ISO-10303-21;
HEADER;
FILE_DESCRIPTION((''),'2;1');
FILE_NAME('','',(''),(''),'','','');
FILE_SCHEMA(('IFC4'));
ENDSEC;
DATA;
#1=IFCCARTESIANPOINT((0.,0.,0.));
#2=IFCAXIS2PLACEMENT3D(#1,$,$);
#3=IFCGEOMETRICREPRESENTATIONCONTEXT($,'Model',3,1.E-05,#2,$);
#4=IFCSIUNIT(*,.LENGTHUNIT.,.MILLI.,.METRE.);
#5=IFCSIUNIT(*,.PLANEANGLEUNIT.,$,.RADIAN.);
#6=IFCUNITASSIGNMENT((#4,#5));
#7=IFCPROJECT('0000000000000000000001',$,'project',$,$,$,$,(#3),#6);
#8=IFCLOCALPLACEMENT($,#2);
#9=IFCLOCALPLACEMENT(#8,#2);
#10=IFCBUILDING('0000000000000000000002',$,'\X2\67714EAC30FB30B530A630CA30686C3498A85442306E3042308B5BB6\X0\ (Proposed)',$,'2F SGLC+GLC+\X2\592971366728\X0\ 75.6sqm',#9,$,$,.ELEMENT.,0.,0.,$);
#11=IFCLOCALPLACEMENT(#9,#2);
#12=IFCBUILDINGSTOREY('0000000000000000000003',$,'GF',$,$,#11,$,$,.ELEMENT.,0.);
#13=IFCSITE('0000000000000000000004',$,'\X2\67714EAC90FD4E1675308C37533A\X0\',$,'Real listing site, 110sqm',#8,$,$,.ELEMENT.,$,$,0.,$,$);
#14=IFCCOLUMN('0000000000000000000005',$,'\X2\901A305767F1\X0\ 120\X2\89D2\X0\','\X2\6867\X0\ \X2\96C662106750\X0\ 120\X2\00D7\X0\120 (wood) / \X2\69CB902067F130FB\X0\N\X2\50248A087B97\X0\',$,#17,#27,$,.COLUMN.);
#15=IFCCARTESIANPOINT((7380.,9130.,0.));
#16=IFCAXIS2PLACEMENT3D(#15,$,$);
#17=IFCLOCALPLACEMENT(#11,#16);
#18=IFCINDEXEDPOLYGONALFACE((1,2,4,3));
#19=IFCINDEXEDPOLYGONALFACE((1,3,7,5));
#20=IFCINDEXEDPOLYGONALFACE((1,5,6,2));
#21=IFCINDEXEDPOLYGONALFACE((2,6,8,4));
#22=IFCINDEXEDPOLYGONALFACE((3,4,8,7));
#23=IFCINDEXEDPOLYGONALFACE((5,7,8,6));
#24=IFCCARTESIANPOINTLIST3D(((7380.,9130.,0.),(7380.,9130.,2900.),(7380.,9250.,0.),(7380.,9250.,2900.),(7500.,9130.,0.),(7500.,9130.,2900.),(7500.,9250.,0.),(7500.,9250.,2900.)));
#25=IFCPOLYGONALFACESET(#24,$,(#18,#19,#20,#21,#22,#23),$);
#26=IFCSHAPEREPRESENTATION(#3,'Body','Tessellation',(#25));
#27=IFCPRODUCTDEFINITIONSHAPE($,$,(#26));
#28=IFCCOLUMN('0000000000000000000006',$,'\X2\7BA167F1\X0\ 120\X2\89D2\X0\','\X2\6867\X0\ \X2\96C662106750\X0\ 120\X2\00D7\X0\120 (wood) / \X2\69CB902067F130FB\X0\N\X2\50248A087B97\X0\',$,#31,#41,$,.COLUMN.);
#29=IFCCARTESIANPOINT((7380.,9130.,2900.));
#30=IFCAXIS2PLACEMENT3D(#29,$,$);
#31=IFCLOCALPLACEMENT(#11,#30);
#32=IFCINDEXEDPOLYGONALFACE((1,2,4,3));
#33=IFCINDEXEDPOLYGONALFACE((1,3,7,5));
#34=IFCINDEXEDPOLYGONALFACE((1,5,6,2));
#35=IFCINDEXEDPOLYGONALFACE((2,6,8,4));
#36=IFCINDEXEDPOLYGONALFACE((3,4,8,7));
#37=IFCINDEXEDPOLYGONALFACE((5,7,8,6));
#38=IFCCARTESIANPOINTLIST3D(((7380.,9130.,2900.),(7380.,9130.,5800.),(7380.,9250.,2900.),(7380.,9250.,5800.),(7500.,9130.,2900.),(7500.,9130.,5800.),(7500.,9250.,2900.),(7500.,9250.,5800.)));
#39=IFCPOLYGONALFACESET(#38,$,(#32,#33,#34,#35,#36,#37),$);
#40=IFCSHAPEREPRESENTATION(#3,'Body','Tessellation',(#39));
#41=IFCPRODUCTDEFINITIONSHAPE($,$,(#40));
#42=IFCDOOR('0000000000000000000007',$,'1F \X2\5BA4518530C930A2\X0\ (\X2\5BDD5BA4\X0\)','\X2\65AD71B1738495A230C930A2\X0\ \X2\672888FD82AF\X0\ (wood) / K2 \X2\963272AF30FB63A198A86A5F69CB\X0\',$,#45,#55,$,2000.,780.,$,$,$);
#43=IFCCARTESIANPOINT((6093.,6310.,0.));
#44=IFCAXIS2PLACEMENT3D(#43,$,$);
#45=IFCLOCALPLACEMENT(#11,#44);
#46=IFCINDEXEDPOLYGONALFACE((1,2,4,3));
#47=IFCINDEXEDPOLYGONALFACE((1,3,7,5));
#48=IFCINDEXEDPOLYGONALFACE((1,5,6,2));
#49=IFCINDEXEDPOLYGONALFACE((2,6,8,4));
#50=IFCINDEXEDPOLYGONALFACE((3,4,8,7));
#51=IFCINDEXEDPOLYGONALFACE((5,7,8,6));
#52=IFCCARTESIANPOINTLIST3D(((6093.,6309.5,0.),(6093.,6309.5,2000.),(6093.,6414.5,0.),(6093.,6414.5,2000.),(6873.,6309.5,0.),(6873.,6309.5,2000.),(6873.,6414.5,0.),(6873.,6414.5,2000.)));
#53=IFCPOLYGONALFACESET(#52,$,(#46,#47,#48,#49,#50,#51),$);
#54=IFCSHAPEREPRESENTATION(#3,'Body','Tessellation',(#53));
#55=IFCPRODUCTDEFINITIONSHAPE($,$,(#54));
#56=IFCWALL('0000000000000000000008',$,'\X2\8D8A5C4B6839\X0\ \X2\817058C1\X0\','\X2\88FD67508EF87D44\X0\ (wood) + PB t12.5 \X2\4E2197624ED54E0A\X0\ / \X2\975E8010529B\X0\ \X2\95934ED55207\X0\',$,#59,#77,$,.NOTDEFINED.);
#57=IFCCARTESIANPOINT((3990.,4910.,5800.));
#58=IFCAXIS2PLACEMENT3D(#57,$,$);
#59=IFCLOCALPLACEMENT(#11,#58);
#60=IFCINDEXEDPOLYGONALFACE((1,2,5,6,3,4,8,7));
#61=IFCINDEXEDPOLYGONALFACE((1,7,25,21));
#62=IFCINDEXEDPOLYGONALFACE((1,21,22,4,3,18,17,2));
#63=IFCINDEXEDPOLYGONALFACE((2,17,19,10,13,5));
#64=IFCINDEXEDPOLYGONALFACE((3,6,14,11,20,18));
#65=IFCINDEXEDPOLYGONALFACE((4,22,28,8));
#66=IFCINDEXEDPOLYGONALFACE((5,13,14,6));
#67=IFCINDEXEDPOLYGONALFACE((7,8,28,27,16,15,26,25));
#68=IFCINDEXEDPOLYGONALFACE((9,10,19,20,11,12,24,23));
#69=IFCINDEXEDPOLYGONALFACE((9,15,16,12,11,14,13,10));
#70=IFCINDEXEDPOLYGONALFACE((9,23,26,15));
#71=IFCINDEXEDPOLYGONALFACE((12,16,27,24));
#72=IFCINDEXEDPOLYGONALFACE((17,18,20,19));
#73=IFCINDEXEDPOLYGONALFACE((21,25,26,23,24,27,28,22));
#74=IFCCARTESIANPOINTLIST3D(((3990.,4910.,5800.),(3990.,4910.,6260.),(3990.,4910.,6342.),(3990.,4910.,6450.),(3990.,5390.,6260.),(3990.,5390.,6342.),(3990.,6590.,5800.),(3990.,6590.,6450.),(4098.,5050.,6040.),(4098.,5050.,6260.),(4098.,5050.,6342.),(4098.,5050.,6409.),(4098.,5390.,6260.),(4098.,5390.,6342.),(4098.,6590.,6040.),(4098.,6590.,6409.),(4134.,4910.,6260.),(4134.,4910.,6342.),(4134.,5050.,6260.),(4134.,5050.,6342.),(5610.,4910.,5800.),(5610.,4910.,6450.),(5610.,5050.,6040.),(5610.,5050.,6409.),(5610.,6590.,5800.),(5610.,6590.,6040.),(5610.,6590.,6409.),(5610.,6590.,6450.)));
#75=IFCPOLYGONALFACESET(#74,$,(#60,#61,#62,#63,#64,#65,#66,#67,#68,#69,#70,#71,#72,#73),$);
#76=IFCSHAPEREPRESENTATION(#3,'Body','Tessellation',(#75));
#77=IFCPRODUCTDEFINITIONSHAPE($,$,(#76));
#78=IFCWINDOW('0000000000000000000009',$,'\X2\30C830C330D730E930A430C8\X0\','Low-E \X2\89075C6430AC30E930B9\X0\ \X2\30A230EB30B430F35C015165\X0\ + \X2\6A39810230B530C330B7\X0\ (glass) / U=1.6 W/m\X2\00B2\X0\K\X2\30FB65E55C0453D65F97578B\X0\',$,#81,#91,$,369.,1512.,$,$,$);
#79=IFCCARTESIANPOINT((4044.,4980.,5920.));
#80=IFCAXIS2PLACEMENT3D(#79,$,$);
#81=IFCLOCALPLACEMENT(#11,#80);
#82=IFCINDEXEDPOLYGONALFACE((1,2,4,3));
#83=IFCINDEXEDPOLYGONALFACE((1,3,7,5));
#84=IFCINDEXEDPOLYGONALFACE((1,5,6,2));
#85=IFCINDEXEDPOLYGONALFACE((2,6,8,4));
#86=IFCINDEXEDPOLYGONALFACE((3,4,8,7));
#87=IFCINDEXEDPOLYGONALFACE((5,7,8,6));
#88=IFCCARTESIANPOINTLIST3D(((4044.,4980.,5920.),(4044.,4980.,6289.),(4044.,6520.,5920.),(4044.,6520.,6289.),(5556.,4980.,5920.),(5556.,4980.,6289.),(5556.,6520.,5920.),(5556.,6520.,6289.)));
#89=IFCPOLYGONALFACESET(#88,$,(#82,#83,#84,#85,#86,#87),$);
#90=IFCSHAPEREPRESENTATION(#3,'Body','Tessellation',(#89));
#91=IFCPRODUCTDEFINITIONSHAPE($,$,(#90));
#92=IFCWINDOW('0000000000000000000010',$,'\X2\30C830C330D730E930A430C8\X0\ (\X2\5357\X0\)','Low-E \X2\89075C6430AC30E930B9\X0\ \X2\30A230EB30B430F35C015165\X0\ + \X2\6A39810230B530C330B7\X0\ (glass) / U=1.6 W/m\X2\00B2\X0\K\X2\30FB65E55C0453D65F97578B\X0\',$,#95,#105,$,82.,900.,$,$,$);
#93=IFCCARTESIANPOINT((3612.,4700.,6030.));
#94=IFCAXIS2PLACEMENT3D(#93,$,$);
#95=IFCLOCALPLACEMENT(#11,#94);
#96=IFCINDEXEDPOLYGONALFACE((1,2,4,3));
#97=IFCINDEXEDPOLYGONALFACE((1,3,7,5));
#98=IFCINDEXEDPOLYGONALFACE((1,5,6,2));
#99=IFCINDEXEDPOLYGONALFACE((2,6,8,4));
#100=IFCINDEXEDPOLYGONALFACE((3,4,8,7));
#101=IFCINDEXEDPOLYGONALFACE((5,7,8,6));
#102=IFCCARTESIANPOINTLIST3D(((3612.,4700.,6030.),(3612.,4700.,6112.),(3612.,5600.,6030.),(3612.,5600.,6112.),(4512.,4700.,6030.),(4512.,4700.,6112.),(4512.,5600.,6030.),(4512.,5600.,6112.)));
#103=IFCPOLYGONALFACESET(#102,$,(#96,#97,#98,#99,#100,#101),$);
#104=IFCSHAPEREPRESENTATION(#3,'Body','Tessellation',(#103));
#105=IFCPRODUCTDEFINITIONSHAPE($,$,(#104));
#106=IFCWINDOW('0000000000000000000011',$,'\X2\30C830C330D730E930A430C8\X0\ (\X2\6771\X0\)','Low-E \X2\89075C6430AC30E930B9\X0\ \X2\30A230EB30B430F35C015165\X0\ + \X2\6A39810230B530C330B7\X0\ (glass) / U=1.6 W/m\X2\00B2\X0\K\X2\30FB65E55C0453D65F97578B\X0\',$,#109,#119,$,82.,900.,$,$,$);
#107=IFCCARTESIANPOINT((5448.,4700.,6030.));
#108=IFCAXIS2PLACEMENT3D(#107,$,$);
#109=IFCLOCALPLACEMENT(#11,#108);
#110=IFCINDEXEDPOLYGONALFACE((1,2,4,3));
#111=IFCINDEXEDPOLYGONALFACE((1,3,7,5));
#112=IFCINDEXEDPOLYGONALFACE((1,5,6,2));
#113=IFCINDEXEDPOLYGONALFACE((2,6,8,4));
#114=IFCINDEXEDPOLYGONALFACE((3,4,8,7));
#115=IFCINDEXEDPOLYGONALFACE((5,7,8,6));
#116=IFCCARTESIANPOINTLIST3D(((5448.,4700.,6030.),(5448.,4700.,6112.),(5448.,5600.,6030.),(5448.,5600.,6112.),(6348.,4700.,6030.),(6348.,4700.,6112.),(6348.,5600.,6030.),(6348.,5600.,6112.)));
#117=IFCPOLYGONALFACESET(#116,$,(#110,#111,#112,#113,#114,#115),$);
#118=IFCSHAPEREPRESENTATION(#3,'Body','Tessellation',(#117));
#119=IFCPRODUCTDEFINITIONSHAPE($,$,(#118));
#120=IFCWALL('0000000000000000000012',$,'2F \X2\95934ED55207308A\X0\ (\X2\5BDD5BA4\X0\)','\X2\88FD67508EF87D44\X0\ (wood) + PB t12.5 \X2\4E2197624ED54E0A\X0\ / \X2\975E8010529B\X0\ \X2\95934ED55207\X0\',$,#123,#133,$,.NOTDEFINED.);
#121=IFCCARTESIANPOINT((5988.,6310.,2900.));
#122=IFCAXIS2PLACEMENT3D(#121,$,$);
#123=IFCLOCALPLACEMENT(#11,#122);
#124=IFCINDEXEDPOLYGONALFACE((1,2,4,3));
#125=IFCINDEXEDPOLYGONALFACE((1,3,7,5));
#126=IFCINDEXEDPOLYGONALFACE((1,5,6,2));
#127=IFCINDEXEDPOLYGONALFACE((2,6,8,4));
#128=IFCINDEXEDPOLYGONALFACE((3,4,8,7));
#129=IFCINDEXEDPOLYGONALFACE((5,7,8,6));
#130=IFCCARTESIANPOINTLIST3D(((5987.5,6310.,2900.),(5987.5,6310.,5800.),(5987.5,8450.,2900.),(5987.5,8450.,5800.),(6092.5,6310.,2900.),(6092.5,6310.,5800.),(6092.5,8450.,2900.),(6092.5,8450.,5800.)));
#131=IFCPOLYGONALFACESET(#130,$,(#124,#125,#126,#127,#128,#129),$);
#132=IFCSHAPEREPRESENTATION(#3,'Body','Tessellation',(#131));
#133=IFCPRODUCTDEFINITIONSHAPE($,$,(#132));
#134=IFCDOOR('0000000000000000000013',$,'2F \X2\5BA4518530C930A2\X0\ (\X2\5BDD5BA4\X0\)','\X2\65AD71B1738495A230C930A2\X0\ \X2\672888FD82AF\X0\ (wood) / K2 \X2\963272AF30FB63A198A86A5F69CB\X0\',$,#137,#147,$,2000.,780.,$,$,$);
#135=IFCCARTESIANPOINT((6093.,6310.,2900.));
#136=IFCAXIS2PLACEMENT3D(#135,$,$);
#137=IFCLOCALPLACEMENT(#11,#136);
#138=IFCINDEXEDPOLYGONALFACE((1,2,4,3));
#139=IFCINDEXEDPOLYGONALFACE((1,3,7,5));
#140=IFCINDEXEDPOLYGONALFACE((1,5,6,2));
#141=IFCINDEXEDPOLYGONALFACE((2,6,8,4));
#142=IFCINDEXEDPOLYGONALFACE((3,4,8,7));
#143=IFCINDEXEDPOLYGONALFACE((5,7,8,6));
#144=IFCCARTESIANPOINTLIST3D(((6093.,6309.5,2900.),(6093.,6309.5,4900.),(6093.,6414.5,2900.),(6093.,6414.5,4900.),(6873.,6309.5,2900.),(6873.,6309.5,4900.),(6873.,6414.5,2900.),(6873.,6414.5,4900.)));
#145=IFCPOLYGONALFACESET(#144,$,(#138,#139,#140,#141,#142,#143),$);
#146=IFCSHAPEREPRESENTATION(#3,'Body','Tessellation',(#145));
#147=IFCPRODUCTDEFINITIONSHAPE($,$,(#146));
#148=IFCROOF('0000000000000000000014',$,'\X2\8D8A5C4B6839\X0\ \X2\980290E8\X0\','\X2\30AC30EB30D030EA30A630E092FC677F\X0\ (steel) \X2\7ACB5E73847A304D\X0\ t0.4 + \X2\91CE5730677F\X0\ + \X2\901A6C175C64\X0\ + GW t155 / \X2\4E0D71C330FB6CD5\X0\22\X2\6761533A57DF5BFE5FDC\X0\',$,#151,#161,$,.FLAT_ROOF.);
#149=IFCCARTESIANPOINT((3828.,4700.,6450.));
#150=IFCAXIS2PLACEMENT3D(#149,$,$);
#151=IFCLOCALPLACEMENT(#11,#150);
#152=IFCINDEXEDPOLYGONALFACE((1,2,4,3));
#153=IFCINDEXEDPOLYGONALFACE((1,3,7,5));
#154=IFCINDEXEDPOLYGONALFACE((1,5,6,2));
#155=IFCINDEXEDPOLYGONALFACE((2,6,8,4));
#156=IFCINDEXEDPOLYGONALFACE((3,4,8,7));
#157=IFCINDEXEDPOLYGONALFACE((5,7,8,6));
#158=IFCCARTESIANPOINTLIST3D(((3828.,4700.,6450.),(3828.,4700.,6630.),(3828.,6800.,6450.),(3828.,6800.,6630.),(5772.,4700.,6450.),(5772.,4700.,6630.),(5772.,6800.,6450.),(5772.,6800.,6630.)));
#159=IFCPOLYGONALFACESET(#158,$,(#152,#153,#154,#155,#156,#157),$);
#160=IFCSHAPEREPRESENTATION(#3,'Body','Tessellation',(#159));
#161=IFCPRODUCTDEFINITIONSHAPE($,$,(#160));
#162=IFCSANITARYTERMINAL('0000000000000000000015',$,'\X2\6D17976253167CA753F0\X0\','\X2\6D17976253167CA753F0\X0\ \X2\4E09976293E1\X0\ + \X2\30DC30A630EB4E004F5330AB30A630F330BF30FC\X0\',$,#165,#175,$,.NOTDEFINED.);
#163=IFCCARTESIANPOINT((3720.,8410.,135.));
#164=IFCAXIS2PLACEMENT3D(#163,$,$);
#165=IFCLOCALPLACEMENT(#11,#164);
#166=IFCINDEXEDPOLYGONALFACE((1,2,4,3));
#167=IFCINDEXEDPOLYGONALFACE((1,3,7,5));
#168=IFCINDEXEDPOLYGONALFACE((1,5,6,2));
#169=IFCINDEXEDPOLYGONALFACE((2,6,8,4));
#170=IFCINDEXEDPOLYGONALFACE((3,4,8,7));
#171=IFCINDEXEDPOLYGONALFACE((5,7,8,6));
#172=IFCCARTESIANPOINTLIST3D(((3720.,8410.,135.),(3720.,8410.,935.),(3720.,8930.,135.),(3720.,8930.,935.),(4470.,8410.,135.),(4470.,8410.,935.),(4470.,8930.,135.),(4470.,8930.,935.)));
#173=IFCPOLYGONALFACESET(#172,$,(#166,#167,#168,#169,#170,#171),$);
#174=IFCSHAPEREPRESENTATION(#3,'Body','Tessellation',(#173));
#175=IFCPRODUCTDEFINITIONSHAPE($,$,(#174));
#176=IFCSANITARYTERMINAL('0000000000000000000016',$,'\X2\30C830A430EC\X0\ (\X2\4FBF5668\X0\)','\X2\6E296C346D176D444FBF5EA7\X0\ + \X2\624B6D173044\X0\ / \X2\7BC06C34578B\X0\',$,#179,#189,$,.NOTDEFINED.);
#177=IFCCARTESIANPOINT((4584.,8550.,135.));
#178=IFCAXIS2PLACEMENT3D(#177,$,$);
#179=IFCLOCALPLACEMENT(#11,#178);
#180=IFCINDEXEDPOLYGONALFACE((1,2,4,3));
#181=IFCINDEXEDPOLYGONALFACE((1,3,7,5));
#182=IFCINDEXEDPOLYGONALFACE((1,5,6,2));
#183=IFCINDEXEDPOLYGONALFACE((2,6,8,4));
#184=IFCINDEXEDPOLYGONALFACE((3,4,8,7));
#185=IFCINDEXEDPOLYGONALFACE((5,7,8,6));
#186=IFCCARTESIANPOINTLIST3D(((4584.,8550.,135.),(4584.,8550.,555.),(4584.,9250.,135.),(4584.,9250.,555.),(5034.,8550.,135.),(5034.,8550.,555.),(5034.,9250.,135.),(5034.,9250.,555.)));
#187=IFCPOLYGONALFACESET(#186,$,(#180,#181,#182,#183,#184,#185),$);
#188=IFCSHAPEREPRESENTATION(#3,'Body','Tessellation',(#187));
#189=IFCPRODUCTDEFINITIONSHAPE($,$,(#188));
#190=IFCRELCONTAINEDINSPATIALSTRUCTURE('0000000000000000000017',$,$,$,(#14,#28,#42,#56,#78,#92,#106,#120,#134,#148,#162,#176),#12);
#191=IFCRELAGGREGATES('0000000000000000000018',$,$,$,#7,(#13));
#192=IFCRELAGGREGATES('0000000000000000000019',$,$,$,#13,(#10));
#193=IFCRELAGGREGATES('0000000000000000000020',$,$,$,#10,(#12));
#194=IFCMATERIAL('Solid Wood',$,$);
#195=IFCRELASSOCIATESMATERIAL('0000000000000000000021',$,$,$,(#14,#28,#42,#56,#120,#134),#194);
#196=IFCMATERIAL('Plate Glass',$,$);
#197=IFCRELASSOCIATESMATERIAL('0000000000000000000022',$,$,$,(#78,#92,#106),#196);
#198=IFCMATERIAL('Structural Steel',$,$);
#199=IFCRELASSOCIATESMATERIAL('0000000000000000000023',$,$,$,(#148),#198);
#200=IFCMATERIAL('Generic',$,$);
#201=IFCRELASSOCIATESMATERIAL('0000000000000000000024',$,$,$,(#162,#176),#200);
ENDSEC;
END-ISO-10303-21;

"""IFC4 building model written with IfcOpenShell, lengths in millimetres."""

from ifc_helpers import new_model, si_unit, frame, frame_2d, origin, place, context, project, spatial, rectangle, extrude, material, element, fill, save


model = new_model("IFC4")

# Units and contexts
model_context = context("Model", 3, precision=1e-05, world=origin())
ifc_project = project(units=[si_unit("LENGTHUNIT", "METRE", prefix="MILLI"), si_unit("PLANEANGLEUNIT", "RADIAN")], contexts=[model_context])

# Site, building, storey
site_placement = place(None, origin())
site = spatial("IfcSite", under=ifc_project, at=site_placement, Name="東京都世田谷区", ObjectType="Real listing site, 110sqm", CompositionType="ELEMENT", RefElevation=0.0)
building_placement = place(site_placement, origin())
building = spatial("IfcBuilding", under=site, at=building_placement, Name="東京・サウナと水風呂のある家 (Proposed)", ObjectType="2F SGLC+GLC+天然木 75.6sqm", CompositionType="ELEMENT", ElevationOfRefHeight=0.0, ElevationOfTerrain=0.0)
storey_placement = place(building_placement, origin())
storey = spatial("IfcBuildingStorey", under=building, at=storey_placement, Name="GF", CompositionType="ELEMENT", Elevation=0.0)

# Columns
ifc_material_1 = material(Name="Solid Wood")
column_1_placement = place(storey_placement, frame((7380.0, 9130.0, 0.0)))
element("IfcColumn", 1, at=column_1_placement, inside=storey, material=ifc_material_1, Name="通し柱 120角", Description="桧 集成材 120×120 (wood) / 構造柱・N値計算", PredefinedType="COLUMN", context=model_context, shape_type="SweptSolid", body=[
    extrude(rectangle(XDim=120.0, YDim=120.0, at=frame_2d((60.0, 60.0))), frame((7380.0, 9130.0, 0.0)), (0.0, 0.0, 1.0), 2900.0),
])
column_2_placement = place(storey_placement, frame((7380.0, 9130.0, 2900.0)))
element("IfcColumn", 2, at=column_2_placement, inside=storey, material=ifc_material_1, Name="管柱 120角", Description="桧 集成材 120×120 (wood) / 構造柱・N値計算", PredefinedType="COLUMN", context=model_context, shape_type="SweptSolid", body=[
    extrude(rectangle(XDim=120.0, YDim=120.0, at=frame_2d((60.0, 60.0))), frame((7380.0, 9130.0, 2900.0)), (0.0, 0.0, 1.0), 2900.0),
])

# Door
door_1_placement = place(storey_placement, frame((6093.0, 6310.0, 0.0)))
element("IfcDoor", 3, at=door_1_placement, inside=storey, material=ifc_material_1, Name="1F 室内ドア (寝室)", Description="断熱玄関ドア 木製芯 (wood) / K2 防犯・採風機構", OverallHeight=2000.0, OverallWidth=780.0, context=model_context, shape_type="SweptSolid", body=[
    extrude(rectangle(XDim=780.0, YDim=105.0, at=frame_2d((390.0, 52.0))), frame((6093.0, 6310.0, 0.0)), (0.0, 0.0, 1.0), 2000.0),
])

# Wall, openings, windows
wall_1_placement = place(storey_placement, frame((3990.0, 4910.0, 5800.0)))
wall_1 = element("IfcWall", 4, at=wall_1_placement, inside=storey, material=ifc_material_1, Name="越屋根 腰壁", Description="製材軸組 (wood) + PB t12.5 両面仕上 / 非耐力 間仕切", PredefinedType="NOTDEFINED", context=model_context, shape_type="SweptSolid", body=[
    extrude(rectangle(XDim=1620.0, YDim=1680.0, at=frame_2d((810.0, 840.0))), frame((3990.0, 4910.0, 5800.0)), (0.0, 0.0, 1.0), 650.0),
])
opening_1_placement = place(storey_placement, frame((4044.0, 4980.0, 5920.0)))
opening_1 = element("IfcOpeningElement", 5, at=opening_1_placement, cuts=wall_1, PredefinedType="NOTDEFINED", context=model_context, shape_type="SweptSolid", body=[
    extrude(rectangle(XDim=1512.0, YDim=1540.0, at=frame_2d((756.0, 770.0))), frame((4044.0, 4980.0, 5920.0)), (0.0, 0.0, 1.0), 369.0),
])
opening_2_placement = place(storey_placement, frame((3612.0, 4700.0, 6030.0)))
opening_2 = element("IfcOpeningElement", 6, at=opening_2_placement, cuts=wall_1, PredefinedType="NOTDEFINED", context=model_context, shape_type="SweptSolid", body=[
    extrude(rectangle(XDim=900.0, YDim=900.0, at=frame_2d((450.0, 450.0))), frame((3612.0, 4700.0, 6030.0)), (0.0, 0.0, 1.0), 82.0),
])
opening_3_placement = place(storey_placement, frame((5448.0, 4700.0, 6030.0)))
opening_3 = element("IfcOpeningElement", 7, at=opening_3_placement, cuts=wall_1, PredefinedType="NOTDEFINED", context=model_context, shape_type="SweptSolid", body=[
    extrude(rectangle(XDim=900.0, YDim=900.0, at=frame_2d((450.0, 450.0))), frame((5448.0, 4700.0, 6030.0)), (0.0, 0.0, 1.0), 82.0),
])
ifc_material_2 = material(Name="Plate Glass")
window_1_placement = place(storey_placement, frame((4044.0, 4980.0, 5920.0)))
window_1 = element("IfcWindow", 8, at=window_1_placement, inside=storey, material=ifc_material_2, Name="トップライト", Description="Low-E 複層ガラス アルゴン封入 + 樹脂サッシ (glass) / U=1.6 W/m²K・日射取得型", OverallHeight=369.0, OverallWidth=1512.0, context=model_context, shape_type="SweptSolid", body=[
    extrude(rectangle(XDim=1512.0, YDim=1540.0, at=frame_2d((756.0, 770.0))), frame((4044.0, 4980.0, 5920.0)), (0.0, 0.0, 1.0), 369.0),
])
fill(opening_1, window_1)
window_2_placement = place(storey_placement, frame((3612.0, 4700.0, 6030.0)))
window_2 = element("IfcWindow", 9, at=window_2_placement, inside=storey, material=ifc_material_2, Name="トップライト (南)", Description="Low-E 複層ガラス アルゴン封入 + 樹脂サッシ (glass) / U=1.6 W/m²K・日射取得型", OverallHeight=82.0, OverallWidth=900.0, context=model_context, shape_type="SweptSolid", body=[
    extrude(rectangle(XDim=900.0, YDim=900.0, at=frame_2d((450.0, 450.0))), frame((3612.0, 4700.0, 6030.0)), (0.0, 0.0, 1.0), 82.0),
])
fill(opening_2, window_2)
window_3_placement = place(storey_placement, frame((5448.0, 4700.0, 6030.0)))
window_3 = element("IfcWindow", 10, at=window_3_placement, inside=storey, material=ifc_material_2, Name="トップライト (東)", Description="Low-E 複層ガラス アルゴン封入 + 樹脂サッシ (glass) / U=1.6 W/m²K・日射取得型", OverallHeight=82.0, OverallWidth=900.0, context=model_context, shape_type="SweptSolid", body=[
    extrude(rectangle(XDim=900.0, YDim=900.0, at=frame_2d((450.0, 450.0))), frame((5448.0, 4700.0, 6030.0)), (0.0, 0.0, 1.0), 82.0),
])
fill(opening_3, window_3)

# Wall
wall_2_placement = place(storey_placement, frame((5988.0, 6310.0, 2900.0)))
element("IfcWall", 11, at=wall_2_placement, inside=storey, material=ifc_material_1, Name="2F 間仕切り (寝室)", Description="製材軸組 (wood) + PB t12.5 両面仕上 / 非耐力 間仕切", PredefinedType="NOTDEFINED", context=model_context, shape_type="SweptSolid", body=[
    extrude(rectangle(XDim=105.0, YDim=2140.0, at=frame_2d((52.0, 1070.0))), frame((5988.0, 6310.0, 2900.0)), (0.0, 0.0, 1.0), 2900.0),
])

# Door
door_2_placement = place(storey_placement, frame((6093.0, 6310.0, 2900.0)))
element("IfcDoor", 12, at=door_2_placement, inside=storey, material=ifc_material_1, Name="2F 室内ドア (寝室)", Description="断熱玄関ドア 木製芯 (wood) / K2 防犯・採風機構", OverallHeight=2000.0, OverallWidth=780.0, context=model_context, shape_type="SweptSolid", body=[
    extrude(rectangle(XDim=780.0, YDim=105.0, at=frame_2d((390.0, 52.0))), frame((6093.0, 6310.0, 2900.0)), (0.0, 0.0, 1.0), 2000.0),
])

# Roof
ifc_material_3 = material(Name="Structural Steel")
roof_placement = place(storey_placement, frame((3828.0, 4700.0, 6450.0)))
element("IfcRoof", 13, at=roof_placement, inside=storey, material=ifc_material_3, Name="越屋根 頂部", Description="ガルバリウム鋼板 (steel) 立平葺き t0.4 + 野地板 + 通気層 + GW t155 / 不燃・法22条区域対応", PredefinedType="FLAT_ROOF", context=model_context, shape_type="SweptSolid", body=[
    extrude(rectangle(XDim=1944.0, YDim=2100.0, at=frame_2d((972.0, 1050.0))), frame((3828.0, 4700.0, 6450.0)), (0.0, 0.0, 1.0), 180.0),
])

# Sanitary terminals
ifc_material_4 = material(Name="Generic")
sanitary_terminal_1_placement = place(storey_placement, frame((3720.0, 8410.0, 135.0)))
element("IfcSanitaryTerminal", 14, at=sanitary_terminal_1_placement, inside=storey, material=ifc_material_4, Name="洗面化粧台", Description="洗面化粧台 三面鏡 + ボウル一体カウンター", PredefinedType="NOTDEFINED", context=model_context, shape_type="SweptSolid", body=[
    extrude(rectangle(XDim=750.0, YDim=520.0, at=frame_2d((375.0, 260.0))), frame((3720.0, 8410.0, 135.0)), (0.0, 0.0, 1.0), 800.0),
])
sanitary_terminal_2_placement = place(storey_placement, frame((4584.0, 8550.0, 135.0)))
element("IfcSanitaryTerminal", 15, at=sanitary_terminal_2_placement, inside=storey, material=ifc_material_4, Name="トイレ (便器)", Description="温水洗浄便座 + 手洗い / 節水型", PredefinedType="NOTDEFINED", context=model_context, shape_type="SweptSolid", body=[
    extrude(rectangle(XDim=450.0, YDim=700.0, at=frame_2d((225.0, 350.0))), frame((4584.0, 8550.0, 135.0)), (0.0, 0.0, 1.0), 420.0),
])

save(model, "model.ifc")
